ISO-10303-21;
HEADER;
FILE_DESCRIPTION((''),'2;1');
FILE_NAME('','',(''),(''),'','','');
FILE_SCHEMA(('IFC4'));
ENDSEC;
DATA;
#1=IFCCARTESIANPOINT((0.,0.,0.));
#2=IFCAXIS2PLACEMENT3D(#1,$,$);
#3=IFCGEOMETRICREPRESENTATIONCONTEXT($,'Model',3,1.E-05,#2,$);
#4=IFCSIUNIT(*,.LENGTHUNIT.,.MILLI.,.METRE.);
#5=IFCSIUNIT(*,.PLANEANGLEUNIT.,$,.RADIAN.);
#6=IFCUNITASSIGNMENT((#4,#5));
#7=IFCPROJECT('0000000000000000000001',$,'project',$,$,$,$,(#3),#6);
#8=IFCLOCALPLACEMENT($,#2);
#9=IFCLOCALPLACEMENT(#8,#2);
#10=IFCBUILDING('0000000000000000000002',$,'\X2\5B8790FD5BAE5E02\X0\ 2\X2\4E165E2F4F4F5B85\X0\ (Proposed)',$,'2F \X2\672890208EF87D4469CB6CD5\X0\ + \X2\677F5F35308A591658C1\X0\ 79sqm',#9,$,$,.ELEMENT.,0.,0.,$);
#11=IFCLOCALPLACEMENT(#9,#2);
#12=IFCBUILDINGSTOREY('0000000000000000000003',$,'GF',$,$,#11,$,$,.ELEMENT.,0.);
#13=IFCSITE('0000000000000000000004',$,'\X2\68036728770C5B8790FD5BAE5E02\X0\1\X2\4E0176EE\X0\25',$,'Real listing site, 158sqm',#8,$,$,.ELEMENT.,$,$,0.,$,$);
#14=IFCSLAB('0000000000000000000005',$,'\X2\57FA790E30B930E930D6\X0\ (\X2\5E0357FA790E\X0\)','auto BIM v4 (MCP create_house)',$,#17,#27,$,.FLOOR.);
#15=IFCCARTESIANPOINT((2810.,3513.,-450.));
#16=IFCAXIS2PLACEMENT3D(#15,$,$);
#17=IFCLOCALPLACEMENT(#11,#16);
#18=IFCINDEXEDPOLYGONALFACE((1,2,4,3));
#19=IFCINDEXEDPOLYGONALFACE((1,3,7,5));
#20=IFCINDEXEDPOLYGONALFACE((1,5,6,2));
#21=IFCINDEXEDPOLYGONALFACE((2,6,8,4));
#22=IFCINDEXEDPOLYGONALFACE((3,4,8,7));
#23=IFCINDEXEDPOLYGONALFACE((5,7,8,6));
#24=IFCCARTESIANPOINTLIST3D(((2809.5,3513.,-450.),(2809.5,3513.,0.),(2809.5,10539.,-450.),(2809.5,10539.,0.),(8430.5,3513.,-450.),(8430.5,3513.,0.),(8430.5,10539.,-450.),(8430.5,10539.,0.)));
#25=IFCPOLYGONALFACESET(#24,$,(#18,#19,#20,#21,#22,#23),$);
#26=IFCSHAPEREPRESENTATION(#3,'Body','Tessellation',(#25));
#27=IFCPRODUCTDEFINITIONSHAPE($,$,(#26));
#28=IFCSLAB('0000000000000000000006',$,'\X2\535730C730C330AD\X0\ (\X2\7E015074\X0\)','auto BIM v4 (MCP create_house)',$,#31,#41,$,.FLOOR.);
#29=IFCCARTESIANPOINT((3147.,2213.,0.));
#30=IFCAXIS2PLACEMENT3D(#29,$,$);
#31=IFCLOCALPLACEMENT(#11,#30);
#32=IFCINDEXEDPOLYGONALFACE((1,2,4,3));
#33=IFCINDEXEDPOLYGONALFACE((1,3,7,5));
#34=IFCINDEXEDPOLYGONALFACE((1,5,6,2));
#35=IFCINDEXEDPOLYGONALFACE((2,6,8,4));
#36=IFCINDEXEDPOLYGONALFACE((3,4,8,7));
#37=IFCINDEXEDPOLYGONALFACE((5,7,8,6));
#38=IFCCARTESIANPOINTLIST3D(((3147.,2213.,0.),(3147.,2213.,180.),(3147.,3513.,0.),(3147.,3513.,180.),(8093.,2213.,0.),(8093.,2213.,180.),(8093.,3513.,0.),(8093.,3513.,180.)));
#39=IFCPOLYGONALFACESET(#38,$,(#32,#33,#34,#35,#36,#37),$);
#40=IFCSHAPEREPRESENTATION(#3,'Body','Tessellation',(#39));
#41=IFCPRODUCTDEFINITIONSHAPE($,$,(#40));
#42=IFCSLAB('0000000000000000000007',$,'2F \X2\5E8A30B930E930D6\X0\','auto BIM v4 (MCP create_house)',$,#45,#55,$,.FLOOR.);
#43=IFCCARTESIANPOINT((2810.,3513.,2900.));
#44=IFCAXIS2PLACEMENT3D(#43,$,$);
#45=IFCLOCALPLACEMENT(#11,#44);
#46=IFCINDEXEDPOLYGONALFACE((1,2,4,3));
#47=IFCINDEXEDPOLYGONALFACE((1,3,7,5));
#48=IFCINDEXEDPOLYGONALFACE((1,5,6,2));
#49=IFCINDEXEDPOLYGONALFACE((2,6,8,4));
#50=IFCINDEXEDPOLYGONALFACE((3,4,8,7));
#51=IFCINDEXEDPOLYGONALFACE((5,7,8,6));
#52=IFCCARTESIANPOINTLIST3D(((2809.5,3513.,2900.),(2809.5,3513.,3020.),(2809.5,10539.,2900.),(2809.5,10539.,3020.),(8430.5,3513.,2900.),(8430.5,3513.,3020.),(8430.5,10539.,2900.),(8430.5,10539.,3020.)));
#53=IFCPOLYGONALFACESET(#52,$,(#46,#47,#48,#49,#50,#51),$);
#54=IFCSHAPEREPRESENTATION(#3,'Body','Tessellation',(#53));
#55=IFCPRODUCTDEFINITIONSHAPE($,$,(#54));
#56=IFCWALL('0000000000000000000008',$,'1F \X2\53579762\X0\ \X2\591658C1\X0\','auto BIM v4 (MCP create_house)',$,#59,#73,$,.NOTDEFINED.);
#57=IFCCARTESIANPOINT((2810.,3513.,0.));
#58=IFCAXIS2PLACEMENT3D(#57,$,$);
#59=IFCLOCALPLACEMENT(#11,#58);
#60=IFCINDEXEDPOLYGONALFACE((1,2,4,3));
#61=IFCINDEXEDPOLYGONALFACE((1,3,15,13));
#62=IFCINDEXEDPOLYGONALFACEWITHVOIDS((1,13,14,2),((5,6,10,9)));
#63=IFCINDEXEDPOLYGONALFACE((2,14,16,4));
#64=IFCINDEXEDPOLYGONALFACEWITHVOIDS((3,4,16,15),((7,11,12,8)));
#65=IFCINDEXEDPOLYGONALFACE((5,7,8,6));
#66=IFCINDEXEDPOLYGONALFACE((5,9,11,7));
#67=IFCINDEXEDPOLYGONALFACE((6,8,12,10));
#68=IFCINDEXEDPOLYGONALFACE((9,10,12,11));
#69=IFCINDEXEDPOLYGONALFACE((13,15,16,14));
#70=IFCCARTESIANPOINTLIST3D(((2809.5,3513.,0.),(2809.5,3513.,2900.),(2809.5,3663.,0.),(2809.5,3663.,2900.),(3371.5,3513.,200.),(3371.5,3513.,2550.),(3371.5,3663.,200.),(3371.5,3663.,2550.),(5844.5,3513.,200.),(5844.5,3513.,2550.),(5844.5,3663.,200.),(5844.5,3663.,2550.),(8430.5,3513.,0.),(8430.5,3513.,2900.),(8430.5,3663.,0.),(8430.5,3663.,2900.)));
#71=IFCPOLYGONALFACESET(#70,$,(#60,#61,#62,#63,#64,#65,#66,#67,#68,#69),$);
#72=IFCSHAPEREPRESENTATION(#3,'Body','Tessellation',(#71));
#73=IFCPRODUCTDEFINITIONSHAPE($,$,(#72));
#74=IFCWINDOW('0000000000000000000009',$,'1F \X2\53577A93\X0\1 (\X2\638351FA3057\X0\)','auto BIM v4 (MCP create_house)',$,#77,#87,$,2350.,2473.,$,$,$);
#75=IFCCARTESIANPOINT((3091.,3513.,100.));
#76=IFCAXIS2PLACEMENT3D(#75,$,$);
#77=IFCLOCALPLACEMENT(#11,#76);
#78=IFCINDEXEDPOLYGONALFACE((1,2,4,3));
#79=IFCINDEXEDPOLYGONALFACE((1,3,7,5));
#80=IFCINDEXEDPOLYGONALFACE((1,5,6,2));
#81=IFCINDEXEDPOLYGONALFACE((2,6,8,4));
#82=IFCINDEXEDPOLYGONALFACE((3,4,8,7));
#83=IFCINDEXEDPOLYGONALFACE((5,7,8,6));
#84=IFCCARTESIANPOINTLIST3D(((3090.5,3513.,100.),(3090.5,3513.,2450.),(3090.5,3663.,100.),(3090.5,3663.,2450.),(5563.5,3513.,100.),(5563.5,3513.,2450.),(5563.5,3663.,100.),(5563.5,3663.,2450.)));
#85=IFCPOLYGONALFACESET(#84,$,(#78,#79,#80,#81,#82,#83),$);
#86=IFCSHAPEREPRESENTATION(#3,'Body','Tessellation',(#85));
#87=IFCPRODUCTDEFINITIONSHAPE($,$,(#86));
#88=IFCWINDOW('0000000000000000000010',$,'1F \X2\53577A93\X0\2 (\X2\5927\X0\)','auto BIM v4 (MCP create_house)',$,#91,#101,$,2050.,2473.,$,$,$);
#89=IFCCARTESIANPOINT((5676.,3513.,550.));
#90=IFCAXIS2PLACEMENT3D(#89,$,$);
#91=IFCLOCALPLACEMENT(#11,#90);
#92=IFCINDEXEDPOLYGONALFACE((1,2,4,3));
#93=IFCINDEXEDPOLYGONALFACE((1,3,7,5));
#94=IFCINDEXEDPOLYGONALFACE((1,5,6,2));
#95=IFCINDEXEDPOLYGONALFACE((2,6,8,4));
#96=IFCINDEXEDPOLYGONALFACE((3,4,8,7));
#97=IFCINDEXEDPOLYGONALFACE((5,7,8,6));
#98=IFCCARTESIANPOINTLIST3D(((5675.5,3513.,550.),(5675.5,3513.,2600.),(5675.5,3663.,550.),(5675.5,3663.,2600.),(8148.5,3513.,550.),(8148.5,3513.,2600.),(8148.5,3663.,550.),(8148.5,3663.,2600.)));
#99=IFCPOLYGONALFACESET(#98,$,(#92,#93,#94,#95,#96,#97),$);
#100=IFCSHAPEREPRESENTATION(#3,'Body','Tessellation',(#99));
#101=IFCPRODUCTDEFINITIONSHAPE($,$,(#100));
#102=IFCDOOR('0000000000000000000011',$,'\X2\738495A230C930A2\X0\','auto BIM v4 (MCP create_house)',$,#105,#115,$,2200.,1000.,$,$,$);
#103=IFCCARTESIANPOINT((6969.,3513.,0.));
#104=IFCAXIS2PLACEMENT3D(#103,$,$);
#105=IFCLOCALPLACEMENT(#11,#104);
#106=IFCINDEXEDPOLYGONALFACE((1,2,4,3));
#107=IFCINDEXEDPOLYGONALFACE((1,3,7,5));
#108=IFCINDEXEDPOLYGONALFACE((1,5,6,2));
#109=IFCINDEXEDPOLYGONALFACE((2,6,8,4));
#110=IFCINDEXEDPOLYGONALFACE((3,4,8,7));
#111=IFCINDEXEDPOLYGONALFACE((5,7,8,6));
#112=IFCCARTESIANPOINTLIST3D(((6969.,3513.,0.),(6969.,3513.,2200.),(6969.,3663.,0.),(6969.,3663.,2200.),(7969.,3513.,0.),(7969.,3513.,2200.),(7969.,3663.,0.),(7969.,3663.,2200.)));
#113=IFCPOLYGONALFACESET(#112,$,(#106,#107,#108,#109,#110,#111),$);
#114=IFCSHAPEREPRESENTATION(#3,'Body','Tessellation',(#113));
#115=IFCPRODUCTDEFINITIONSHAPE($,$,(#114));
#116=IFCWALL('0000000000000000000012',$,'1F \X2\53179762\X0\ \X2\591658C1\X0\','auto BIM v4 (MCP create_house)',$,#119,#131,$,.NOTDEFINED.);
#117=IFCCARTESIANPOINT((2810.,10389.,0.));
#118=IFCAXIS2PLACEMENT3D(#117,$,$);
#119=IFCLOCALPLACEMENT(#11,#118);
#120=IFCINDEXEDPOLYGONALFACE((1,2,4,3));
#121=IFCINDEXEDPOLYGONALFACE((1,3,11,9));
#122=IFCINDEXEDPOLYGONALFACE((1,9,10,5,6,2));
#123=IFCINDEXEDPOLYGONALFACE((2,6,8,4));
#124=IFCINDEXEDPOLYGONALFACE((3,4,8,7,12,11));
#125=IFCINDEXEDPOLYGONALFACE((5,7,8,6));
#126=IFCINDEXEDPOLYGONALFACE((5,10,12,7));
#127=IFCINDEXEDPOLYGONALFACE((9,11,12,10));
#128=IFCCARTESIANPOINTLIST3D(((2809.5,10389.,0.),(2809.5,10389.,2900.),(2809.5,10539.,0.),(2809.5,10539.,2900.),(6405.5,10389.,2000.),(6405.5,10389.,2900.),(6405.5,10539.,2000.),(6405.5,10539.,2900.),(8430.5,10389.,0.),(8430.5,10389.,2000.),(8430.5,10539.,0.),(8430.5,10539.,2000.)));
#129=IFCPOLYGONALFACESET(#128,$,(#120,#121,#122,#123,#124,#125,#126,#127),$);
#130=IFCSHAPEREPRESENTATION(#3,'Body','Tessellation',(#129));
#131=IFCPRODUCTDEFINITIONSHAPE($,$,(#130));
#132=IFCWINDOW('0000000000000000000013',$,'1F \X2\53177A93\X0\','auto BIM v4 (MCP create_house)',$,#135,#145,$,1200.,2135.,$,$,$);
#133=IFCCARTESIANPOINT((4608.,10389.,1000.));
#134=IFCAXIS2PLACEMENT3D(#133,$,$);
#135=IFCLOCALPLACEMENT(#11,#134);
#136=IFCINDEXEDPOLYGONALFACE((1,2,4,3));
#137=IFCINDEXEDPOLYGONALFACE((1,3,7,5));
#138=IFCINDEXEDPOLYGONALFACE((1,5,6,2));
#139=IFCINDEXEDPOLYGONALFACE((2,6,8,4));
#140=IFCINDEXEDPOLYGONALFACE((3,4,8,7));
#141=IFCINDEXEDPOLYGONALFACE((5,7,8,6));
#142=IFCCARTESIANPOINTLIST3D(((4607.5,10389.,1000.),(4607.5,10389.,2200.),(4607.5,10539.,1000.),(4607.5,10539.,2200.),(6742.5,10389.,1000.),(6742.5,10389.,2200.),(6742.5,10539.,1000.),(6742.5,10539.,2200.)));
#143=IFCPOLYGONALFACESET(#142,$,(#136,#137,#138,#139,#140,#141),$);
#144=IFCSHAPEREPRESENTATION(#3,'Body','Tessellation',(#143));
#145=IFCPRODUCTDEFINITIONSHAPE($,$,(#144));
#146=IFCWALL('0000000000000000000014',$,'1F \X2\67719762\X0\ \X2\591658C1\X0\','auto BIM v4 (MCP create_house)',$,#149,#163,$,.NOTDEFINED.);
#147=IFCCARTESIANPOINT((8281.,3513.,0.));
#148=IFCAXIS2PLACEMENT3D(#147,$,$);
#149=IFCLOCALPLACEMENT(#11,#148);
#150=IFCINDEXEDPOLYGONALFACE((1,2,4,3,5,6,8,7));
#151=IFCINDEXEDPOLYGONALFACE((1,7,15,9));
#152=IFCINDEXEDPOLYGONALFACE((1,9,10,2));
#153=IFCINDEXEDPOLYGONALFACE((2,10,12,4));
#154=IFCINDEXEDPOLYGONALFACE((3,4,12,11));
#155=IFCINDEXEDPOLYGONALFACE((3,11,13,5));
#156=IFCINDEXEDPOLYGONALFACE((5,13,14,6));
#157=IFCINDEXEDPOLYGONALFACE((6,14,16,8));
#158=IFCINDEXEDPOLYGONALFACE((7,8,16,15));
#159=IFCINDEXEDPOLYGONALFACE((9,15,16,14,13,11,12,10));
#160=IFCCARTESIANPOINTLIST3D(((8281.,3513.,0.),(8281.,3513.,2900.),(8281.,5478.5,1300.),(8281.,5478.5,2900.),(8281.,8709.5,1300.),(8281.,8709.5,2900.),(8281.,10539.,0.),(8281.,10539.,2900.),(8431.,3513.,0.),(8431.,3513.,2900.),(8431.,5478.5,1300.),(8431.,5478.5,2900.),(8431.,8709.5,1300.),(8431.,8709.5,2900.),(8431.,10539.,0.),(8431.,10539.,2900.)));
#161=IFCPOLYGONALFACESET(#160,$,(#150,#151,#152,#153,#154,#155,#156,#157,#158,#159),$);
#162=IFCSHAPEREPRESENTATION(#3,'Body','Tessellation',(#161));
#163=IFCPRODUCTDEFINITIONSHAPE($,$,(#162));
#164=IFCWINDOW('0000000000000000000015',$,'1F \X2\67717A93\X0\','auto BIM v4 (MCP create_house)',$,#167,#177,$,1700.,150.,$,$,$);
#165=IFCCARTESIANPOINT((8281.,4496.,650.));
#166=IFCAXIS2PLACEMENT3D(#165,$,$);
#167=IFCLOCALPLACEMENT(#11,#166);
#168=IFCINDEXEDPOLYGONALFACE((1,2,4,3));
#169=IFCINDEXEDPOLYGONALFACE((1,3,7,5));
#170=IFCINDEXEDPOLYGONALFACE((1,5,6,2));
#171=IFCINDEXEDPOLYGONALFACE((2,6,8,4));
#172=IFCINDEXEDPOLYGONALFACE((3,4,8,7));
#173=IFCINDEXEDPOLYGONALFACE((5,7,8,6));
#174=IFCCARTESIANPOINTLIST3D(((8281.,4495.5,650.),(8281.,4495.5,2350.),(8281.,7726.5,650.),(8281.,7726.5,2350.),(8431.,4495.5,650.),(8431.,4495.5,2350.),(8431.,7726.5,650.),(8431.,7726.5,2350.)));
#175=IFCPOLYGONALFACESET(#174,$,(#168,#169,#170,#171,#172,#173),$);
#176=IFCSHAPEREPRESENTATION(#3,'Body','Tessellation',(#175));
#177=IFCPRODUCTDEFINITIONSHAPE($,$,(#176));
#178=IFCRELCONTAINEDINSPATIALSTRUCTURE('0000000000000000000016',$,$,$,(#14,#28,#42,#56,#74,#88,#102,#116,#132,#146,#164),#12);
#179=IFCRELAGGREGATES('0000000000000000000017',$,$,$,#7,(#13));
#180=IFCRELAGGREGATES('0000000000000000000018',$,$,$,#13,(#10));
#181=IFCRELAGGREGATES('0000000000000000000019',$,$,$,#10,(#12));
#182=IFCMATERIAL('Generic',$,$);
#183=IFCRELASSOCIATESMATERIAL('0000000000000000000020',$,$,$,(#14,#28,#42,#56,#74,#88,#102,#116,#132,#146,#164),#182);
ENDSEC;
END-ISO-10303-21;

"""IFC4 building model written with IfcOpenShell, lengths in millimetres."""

from ifc_helpers import new_model, si_unit, frame, frame_2d, origin, place, context, project, spatial, rectangle, extrude, material, element, fill, save


model = new_model("IFC4")

# Units and contexts
model_context = context("Model", 3, precision=1e-05, world=origin())
ifc_project = project(units=[si_unit("LENGTHUNIT", "METRE", prefix="MILLI"), si_unit("PLANEANGLEUNIT", "RADIAN")], contexts=[model_context])

# Site, building, storey
site_placement = place(None, origin())
site = spatial("IfcSite", under=ifc_project, at=site_placement, Name="栃木県宇都宮市1丁目25", ObjectType="Real listing site, 158sqm", CompositionType="ELEMENT", RefElevation=0.0)
building_placement = place(site_placement, origin())
building = spatial("IfcBuilding", under=site, at=building_placement, Name="宇都宮市 2世帯住宅 (Proposed)", ObjectType="2F 木造軸組構法 + 板張り外壁 79sqm", CompositionType="ELEMENT", ElevationOfRefHeight=0.0, ElevationOfTerrain=0.0)
storey_placement = place(building_placement, origin())
storey = spatial("IfcBuildingStorey", under=building, at=storey_placement, Name="GF", CompositionType="ELEMENT", Elevation=0.0)

# Slabs
ifc_material = material(Name="Generic")
slab_1_placement = place(storey_placement, frame((2810.0, 3513.0, -450.0)))
element("IfcSlab", 1, at=slab_1_placement, inside=storey, material=ifc_material, Name="基礎スラブ (布基礎)", Description="auto BIM v4 (MCP create_house)", PredefinedType="FLOOR", context=model_context, shape_type="SweptSolid", body=[
    extrude(rectangle(XDim=5621.0, YDim=7026.0, at=frame_2d((2810.0, 3513.0))), frame((2810.0, 3513.0, -450.0)), (0.0, 0.0, 1.0), 450.0),
])
slab_2_placement = place(storey_placement, frame((3147.0, 2213.0, 0.0)))
element("IfcSlab", 2, at=slab_2_placement, inside=storey, material=ifc_material, Name="南デッキ (縁側)", Description="auto BIM v4 (MCP create_house)", PredefinedType="FLOOR", context=model_context, shape_type="SweptSolid", body=[
    extrude(rectangle(XDim=4946.0, YDim=1300.0, at=frame_2d((2473.0, 650.0))), frame((3147.0, 2213.0, 0.0)), (0.0, 0.0, 1.0), 180.0),
])
slab_3_placement = place(storey_placement, frame((2810.0, 3513.0, 2900.0)))
element("IfcSlab", 3, at=slab_3_placement, inside=storey, material=ifc_material, Name="2F 床スラブ", Description="auto BIM v4 (MCP create_house)", PredefinedType="FLOOR", context=model_context, shape_type="SweptSolid", body=[
    extrude(rectangle(XDim=5621.0, YDim=7026.0, at=frame_2d((2810.0, 3513.0))), frame((2810.0, 3513.0, 2900.0)), (0.0, 0.0, 1.0), 120.0),
])

# Wall, openings, windows, door
wall_1_placement = place(storey_placement, frame((2810.0, 3513.0, 0.0)))
wall_1 = element("IfcWall", 4, at=wall_1_placement, inside=storey, material=ifc_material, Name="1F 南面 外壁", Description="auto BIM v4 (MCP create_house)", PredefinedType="NOTDEFINED", context=model_context, shape_type="SweptSolid", body=[
    extrude(rectangle(XDim=5621.0, YDim=150.0, at=frame_2d((2810.0, 75.0))), frame((2810.0, 3513.0, 0.0)), (0.0, 0.0, 1.0), 2900.0),
])
opening_1_placement = place(storey_placement, frame((3091.0, 3513.0, 100.0)))
opening_1 = element("IfcOpeningElement", 5, at=opening_1_placement, cuts=wall_1, PredefinedType="NOTDEFINED", context=model_context, shape_type="SweptSolid", body=[
    extrude(rectangle(XDim=2473.0, YDim=150.0, at=frame_2d((1236.0, 75.0))), frame((3091.0, 3513.0, 100.0)), (0.0, 0.0, 1.0), 2350.0),
])
opening_2_placement = place(storey_placement, frame((5676.0, 3513.0, 550.0)))
opening_2 = element("IfcOpeningElement", 6, at=opening_2_placement, cuts=wall_1, PredefinedType="NOTDEFINED", context=model_context, shape_type="SweptSolid", body=[
    extrude(rectangle(XDim=2473.0, YDim=150.0, at=frame_2d((1236.0, 75.0))), frame((5676.0, 3513.0, 550.0)), (0.0, 0.0, 1.0), 2050.0),
])
opening_3_placement = place(storey_placement, frame((6969.0, 3513.0, 0.0)))
opening_3 = element("IfcOpeningElement", 7, at=opening_3_placement, cuts=wall_1, PredefinedType="NOTDEFINED", context=model_context, shape_type="SweptSolid", body=[
    extrude(rectangle(XDim=1000.0, YDim=150.0, at=frame_2d((500.0, 75.0))), frame((6969.0, 3513.0, 0.0)), (0.0, 0.0, 1.0), 2200.0),
])
window_1_placement = place(storey_placement, frame((3091.0, 3513.0, 100.0)))
window_1 = element("IfcWindow", 8, at=window_1_placement, inside=storey, material=ifc_material, Name="1F 南窓1 (掃出し)", Description="auto BIM v4 (MCP create_house)", OverallHeight=2350.0, OverallWidth=2473.0, context=model_context, shape_type="SweptSolid", body=[
    extrude(rectangle(XDim=2473.0, YDim=150.0, at=frame_2d((1236.0, 75.0))), frame((3091.0, 3513.0, 100.0)), (0.0, 0.0, 1.0), 2350.0),
])
fill(opening_1, window_1)
window_2_placement = place(storey_placement, frame((5676.0, 3513.0, 550.0)))
window_2 = element("IfcWindow", 9, at=window_2_placement, inside=storey, material=ifc_material, Name="1F 南窓2 (大)", Description="auto BIM v4 (MCP create_house)", OverallHeight=2050.0, OverallWidth=2473.0, context=model_context, shape_type="SweptSolid", body=[
    extrude(rectangle(XDim=2473.0, YDim=150.0, at=frame_2d((1236.0, 75.0))), frame((5676.0, 3513.0, 550.0)), (0.0, 0.0, 1.0), 2050.0),
])
fill(opening_2, window_2)
door_1_placement = place(storey_placement, frame((6969.0, 3513.0, 0.0)))
door_1 = element("IfcDoor", 10, at=door_1_placement, inside=storey, material=ifc_material, Name="玄関ドア", Description="auto BIM v4 (MCP create_house)", OverallHeight=2200.0, OverallWidth=1000.0, context=model_context, shape_type="SweptSolid", body=[
    extrude(rectangle(XDim=1000.0, YDim=150.0, at=frame_2d((500.0, 75.0))), frame((6969.0, 3513.0, 0.0)), (0.0, 0.0, 1.0), 2200.0),
])
fill(opening_3, door_1)

# Walls, openings, windows
wall_2_placement = place(storey_placement, frame((2810.0, 10389.0, 0.0)))
wall_2 = element("IfcWall", 11, at=wall_2_placement, inside=storey, material=ifc_material, Name="1F 北面 外壁", Description="auto BIM v4 (MCP create_house)", PredefinedType="NOTDEFINED", context=model_context, shape_type="SweptSolid", body=[
    extrude(rectangle(XDim=5621.0, YDim=150.0, at=frame_2d((2810.0, 75.0))), frame((2810.0, 10389.0, 0.0)), (0.0, 0.0, 1.0), 2900.0),
])
opening_4_placement = place(storey_placement, frame((4608.0, 10389.0, 1000.0)))
opening_4 = element("IfcOpeningElement", 12, at=opening_4_placement, cuts=wall_2, PredefinedType="NOTDEFINED", context=model_context, shape_type="SweptSolid", body=[
    extrude(rectangle(XDim=2135.0, YDim=150.0, at=frame_2d((1067.0, 75.0))), frame((4608.0, 10389.0, 1000.0)), (0.0, 0.0, 1.0), 1200.0),
])
window_3_placement = place(storey_placement, frame((4608.0, 10389.0, 1000.0)))
window_3 = element("IfcWindow", 13, at=window_3_placement, inside=storey, material=ifc_material, Name="1F 北窓", Description="auto BIM v4 (MCP create_house)", OverallHeight=1200.0, OverallWidth=2135.0, context=model_context, shape_type="SweptSolid", body=[
    extrude(rectangle(XDim=2135.0, YDim=150.0, at=frame_2d((1067.0, 75.0))), frame((4608.0, 10389.0, 1000.0)), (0.0, 0.0, 1.0), 1200.0),
])
fill(opening_4, window_3)
wall_3_placement = place(storey_placement, frame((8281.0, 3513.0, 0.0)))
wall_3 = element("IfcWall", 14, at=wall_3_placement, inside=storey, material=ifc_material, Name="1F 東面 外壁", Description="auto BIM v4 (MCP create_house)", PredefinedType="NOTDEFINED", context=model_context, shape_type="SweptSolid", body=[
    extrude(rectangle(XDim=150.0, YDim=7026.0, at=frame_2d((75.0, 3513.0))), frame((8281.0, 3513.0, 0.0)), (0.0, 0.0, 1.0), 2900.0),
])
opening_5_placement = place(storey_placement, frame((8281.0, 4496.0, 650.0)))
opening_5 = element("IfcOpeningElement", 15, at=opening_5_placement, cuts=wall_3, PredefinedType="NOTDEFINED", context=model_context, shape_type="SweptSolid", body=[
    extrude(rectangle(XDim=150.0, YDim=3231.0, at=frame_2d((75.0, 1615.0))), frame((8281.0, 4496.0, 650.0)), (0.0, 0.0, 1.0), 1700.0),
])
window_4_placement = place(storey_placement, frame((8281.0, 4496.0, 650.0)))
window_4 = element("IfcWindow", 16, at=window_4_placement, inside=storey, material=ifc_material, Name="1F 東窓", Description="auto BIM v4 (MCP create_house)", OverallHeight=1700.0, OverallWidth=150.0, context=model_context, shape_type="SweptSolid", body=[
    extrude(rectangle(XDim=150.0, YDim=3231.0, at=frame_2d((75.0, 1615.0))), frame((8281.0, 4496.0, 650.0)), (0.0, 0.0, 1.0), 1700.0),
])
fill(opening_5, window_4)

save(model, "model.ifc")
